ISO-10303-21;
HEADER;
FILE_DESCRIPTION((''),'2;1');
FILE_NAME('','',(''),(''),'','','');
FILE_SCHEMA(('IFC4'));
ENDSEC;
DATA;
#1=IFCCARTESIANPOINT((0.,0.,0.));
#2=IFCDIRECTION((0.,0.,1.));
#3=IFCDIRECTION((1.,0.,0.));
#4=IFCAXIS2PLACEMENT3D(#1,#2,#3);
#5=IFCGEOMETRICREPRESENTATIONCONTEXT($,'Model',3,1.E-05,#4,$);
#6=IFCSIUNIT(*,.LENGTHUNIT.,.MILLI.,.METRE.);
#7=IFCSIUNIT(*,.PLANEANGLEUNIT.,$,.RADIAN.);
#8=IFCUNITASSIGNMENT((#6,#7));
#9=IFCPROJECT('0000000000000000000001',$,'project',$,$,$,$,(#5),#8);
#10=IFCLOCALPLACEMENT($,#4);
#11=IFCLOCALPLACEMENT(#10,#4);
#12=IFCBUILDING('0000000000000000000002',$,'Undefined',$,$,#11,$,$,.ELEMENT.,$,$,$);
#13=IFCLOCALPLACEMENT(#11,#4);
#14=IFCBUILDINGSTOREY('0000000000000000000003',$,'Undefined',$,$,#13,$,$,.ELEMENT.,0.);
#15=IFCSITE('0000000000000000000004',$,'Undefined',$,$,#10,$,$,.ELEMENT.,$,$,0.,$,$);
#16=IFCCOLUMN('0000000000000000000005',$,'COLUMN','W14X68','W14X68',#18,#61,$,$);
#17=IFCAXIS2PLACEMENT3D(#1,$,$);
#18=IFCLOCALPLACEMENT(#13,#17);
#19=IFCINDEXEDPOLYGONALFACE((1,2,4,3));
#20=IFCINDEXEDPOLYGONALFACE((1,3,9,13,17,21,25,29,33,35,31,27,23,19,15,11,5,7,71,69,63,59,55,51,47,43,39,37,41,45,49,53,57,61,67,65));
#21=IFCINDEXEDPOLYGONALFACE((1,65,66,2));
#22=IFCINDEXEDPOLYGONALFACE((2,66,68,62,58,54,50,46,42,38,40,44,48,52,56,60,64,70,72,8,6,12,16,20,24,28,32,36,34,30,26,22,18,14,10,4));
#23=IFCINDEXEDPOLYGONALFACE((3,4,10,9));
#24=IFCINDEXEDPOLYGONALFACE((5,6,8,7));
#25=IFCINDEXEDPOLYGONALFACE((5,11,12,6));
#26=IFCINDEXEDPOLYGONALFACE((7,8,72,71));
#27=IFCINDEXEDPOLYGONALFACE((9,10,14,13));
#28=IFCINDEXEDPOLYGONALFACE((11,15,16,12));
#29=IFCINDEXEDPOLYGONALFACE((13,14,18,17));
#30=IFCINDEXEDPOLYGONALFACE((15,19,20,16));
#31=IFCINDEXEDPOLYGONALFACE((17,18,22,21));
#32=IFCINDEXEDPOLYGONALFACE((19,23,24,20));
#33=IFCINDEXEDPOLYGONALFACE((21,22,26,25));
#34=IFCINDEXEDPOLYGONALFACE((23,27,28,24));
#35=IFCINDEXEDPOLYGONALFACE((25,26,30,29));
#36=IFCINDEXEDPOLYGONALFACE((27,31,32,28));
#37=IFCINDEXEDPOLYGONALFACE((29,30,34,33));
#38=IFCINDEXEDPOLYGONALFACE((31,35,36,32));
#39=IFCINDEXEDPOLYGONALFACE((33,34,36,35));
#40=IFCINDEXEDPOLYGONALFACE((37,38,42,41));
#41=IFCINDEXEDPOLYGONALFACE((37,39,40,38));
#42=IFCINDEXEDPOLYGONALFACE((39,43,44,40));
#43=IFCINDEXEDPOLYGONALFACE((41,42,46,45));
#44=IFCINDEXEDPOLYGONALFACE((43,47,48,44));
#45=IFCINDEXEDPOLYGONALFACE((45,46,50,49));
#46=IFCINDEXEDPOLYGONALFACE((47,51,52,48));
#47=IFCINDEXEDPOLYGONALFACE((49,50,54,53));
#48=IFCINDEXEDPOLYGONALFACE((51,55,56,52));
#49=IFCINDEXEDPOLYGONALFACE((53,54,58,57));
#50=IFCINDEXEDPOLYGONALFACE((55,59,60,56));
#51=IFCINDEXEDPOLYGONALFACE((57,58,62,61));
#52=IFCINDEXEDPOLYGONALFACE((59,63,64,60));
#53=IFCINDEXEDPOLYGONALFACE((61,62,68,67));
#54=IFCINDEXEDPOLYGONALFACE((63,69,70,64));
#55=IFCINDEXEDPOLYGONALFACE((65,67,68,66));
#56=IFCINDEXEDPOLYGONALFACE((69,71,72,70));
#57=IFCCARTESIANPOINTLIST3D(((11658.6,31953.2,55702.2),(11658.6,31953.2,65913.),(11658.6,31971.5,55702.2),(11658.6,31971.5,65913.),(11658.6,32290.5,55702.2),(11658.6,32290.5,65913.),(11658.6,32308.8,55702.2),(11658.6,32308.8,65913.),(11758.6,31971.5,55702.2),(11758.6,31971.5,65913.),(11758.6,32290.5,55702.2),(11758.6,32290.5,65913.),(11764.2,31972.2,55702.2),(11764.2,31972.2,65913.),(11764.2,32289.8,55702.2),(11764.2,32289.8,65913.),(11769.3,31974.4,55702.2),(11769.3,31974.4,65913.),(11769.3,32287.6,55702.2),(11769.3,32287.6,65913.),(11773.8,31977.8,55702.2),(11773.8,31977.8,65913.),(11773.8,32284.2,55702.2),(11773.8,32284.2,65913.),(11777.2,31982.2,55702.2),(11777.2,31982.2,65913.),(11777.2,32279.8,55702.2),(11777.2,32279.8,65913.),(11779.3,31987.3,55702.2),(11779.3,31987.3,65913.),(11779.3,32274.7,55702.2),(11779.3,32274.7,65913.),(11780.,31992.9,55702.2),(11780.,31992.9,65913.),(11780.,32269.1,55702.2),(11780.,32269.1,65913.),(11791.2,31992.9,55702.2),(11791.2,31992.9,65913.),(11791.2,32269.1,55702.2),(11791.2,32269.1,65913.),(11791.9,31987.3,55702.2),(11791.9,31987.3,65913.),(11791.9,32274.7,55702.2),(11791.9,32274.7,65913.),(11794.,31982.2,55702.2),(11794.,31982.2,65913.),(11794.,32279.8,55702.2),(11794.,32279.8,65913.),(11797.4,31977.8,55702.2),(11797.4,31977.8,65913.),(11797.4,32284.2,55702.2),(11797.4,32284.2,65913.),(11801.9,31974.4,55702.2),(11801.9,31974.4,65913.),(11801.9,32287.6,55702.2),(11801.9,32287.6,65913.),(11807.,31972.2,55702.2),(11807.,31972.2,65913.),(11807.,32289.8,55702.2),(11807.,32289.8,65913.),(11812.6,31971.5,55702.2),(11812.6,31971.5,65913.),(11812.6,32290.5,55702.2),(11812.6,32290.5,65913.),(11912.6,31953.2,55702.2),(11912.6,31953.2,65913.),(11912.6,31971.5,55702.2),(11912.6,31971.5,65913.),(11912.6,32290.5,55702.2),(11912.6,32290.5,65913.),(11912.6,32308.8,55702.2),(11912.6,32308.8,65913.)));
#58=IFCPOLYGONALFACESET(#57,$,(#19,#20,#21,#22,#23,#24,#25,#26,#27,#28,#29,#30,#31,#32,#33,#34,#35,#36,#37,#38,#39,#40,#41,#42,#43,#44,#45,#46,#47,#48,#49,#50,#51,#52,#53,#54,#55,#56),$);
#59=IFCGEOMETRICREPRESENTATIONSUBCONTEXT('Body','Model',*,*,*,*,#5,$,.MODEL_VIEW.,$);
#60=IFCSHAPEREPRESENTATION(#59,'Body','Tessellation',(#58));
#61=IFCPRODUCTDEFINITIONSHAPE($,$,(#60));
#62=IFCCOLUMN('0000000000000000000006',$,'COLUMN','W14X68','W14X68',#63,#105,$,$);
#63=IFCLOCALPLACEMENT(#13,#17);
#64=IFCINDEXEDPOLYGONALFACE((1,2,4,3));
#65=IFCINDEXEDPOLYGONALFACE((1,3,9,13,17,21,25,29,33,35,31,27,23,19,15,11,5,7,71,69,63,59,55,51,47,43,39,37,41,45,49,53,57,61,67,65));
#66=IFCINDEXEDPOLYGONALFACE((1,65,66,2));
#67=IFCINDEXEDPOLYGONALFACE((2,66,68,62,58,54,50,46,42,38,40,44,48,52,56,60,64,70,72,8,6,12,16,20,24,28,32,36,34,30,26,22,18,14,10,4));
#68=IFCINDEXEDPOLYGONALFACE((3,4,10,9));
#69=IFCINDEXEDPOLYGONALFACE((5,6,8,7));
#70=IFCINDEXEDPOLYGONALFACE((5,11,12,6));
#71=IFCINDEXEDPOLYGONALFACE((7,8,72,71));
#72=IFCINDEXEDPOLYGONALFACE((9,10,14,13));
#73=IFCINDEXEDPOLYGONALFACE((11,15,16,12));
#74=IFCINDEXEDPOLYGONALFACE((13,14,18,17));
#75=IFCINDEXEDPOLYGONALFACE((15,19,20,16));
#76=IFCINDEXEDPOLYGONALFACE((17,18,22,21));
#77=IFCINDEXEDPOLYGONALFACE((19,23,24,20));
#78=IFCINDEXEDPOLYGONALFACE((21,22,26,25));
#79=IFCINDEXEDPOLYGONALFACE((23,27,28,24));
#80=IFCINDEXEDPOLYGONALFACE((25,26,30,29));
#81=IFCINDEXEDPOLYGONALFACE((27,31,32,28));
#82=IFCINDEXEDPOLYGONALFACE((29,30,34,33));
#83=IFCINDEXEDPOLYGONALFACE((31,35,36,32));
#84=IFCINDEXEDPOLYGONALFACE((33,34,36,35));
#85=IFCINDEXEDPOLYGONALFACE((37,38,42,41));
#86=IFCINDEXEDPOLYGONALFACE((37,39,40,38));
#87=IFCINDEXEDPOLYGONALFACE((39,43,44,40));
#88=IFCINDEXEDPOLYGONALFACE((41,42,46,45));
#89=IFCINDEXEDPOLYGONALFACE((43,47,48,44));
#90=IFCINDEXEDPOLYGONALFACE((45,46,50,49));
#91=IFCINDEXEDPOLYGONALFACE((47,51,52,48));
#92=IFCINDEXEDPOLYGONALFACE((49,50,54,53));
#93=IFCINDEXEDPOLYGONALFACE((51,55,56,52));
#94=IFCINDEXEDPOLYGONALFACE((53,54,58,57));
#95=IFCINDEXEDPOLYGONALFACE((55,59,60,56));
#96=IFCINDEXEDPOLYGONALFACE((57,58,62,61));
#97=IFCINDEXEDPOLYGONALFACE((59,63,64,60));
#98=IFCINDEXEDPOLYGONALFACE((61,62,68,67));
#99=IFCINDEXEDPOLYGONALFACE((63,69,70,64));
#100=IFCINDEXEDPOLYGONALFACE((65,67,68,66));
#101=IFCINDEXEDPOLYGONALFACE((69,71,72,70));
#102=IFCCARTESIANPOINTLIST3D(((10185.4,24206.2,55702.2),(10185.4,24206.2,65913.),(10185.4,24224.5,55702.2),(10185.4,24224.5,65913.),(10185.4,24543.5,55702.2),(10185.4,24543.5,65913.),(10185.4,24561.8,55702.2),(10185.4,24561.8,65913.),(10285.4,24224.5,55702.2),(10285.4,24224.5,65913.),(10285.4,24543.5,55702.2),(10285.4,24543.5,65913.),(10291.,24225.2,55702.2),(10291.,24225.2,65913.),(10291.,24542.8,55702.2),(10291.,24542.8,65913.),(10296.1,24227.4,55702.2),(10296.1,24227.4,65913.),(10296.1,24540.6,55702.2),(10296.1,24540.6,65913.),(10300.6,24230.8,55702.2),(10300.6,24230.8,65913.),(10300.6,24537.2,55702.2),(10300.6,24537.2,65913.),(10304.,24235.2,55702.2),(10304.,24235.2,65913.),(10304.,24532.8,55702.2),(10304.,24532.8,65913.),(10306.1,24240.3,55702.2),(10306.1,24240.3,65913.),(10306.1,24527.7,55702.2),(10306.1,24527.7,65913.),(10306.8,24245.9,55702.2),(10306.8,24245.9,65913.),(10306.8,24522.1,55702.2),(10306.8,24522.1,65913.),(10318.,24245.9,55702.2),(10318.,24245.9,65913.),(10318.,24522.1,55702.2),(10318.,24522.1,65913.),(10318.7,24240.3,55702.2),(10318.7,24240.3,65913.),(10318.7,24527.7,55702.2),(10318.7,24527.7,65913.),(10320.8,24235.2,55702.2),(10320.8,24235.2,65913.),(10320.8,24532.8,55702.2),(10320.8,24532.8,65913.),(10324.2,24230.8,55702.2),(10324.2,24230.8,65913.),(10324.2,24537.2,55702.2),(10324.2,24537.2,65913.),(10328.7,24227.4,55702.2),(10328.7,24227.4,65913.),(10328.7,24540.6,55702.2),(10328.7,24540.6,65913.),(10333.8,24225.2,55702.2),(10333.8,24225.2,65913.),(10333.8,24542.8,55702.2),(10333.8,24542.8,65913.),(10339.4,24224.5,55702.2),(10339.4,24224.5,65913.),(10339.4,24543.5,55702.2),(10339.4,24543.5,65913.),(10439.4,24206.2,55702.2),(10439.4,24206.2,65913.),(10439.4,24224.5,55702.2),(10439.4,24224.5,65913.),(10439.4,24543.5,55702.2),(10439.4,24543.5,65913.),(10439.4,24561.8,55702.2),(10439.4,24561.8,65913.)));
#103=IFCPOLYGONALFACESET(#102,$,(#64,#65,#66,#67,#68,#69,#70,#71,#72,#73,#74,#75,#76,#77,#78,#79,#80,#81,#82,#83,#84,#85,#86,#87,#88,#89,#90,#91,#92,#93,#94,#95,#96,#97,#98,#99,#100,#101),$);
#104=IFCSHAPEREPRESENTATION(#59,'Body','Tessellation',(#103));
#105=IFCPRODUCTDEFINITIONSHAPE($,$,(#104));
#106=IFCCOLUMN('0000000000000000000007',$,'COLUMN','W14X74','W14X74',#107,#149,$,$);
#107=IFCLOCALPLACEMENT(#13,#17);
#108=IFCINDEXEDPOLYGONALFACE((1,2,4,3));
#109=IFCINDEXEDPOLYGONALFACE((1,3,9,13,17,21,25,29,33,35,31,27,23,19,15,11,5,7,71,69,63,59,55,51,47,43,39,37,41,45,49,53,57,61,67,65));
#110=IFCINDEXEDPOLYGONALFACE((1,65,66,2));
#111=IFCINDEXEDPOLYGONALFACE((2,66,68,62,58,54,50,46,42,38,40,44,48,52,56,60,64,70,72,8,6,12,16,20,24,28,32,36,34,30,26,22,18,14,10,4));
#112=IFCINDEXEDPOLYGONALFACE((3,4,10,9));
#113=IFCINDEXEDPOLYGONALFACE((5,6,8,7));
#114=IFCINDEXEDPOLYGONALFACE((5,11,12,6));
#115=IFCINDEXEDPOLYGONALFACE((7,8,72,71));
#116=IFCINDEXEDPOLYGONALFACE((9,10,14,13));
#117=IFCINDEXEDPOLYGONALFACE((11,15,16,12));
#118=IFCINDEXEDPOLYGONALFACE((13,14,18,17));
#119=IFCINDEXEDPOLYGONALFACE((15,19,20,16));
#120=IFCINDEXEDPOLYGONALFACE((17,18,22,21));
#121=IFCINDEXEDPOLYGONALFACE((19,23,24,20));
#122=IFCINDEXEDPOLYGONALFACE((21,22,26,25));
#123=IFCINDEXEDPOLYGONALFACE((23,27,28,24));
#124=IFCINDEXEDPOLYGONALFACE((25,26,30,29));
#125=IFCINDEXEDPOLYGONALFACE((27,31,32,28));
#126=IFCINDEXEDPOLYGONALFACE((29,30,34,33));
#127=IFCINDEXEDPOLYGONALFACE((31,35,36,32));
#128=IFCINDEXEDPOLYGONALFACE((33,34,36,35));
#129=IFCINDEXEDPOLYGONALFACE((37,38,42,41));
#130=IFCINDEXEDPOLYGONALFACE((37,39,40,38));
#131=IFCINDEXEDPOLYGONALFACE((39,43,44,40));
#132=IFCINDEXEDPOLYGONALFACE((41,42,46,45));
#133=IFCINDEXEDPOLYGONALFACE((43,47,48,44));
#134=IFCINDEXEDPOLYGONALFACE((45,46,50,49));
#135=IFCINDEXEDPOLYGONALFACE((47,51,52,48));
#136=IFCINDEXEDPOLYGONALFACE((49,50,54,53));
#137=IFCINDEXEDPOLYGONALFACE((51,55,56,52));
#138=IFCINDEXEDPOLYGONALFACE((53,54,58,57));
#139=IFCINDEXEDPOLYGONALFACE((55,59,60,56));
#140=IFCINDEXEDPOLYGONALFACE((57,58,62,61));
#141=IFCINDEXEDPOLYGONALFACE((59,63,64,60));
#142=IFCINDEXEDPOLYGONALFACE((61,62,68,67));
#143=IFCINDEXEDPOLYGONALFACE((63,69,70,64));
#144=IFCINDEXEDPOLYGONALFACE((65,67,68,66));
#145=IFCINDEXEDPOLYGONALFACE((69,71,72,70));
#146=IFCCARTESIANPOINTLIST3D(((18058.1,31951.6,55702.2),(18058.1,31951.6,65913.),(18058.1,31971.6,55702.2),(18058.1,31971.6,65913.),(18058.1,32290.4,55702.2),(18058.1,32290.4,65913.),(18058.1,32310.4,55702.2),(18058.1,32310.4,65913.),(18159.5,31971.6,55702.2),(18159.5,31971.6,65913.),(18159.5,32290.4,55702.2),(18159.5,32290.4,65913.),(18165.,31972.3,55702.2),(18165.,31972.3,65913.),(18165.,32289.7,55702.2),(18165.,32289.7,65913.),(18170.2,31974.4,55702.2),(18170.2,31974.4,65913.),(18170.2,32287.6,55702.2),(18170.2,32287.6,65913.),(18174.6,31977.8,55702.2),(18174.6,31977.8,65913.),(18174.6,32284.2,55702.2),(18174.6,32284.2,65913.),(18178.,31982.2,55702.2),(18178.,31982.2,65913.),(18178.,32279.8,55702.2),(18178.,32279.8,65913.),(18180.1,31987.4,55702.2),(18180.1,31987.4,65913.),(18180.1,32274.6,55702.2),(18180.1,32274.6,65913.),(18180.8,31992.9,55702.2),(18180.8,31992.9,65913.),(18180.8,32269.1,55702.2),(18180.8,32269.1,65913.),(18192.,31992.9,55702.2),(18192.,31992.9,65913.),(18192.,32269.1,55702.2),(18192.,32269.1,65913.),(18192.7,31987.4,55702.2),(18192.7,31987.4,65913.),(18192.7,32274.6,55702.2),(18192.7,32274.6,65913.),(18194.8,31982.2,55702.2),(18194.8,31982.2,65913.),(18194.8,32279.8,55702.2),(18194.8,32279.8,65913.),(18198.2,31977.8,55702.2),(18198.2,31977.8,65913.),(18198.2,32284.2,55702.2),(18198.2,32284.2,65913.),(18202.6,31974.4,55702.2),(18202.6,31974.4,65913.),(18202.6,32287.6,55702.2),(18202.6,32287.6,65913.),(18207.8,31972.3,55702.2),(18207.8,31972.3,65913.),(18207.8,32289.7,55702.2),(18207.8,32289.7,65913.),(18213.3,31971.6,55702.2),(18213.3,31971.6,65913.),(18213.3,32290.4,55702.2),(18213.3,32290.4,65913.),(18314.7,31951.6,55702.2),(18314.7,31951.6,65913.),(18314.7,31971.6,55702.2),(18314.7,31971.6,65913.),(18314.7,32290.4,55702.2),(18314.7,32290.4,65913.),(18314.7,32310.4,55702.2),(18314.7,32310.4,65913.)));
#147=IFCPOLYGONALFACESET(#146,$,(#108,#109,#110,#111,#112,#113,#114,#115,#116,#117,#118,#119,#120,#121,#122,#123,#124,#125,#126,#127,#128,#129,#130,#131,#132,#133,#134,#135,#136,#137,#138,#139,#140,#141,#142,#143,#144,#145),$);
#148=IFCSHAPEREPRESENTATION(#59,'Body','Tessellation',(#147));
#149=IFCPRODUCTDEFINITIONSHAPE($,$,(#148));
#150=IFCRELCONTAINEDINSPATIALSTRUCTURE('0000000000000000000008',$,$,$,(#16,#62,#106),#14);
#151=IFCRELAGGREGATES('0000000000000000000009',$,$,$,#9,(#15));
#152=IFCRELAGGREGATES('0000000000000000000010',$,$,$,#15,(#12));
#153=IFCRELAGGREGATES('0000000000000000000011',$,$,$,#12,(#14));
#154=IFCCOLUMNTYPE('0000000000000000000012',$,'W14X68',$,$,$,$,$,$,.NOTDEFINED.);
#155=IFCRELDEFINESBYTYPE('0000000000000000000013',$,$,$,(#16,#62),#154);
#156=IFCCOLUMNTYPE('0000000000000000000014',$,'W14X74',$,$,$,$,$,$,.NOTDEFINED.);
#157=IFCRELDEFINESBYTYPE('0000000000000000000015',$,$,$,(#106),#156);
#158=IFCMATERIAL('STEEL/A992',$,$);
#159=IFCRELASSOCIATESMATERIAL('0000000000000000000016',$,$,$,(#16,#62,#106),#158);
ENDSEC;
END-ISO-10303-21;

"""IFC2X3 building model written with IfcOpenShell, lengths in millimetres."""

from ifc_helpers import new_model, si_unit, frame, origin_with_axes, origin_2d_with_axis, place, context, subcontext, project, spatial, i_section, extrude, material, type_object, element, save


model = new_model("IFC2X3")

# Units and contexts
model_context = context("Model", 3, precision=1e-05, world=origin_with_axes())
body_context = subcontext(model_context, "Body", "Model", "MODEL_VIEW")
ifc_project = project(units=[si_unit("LENGTHUNIT", "METRE", prefix="MILLI"), si_unit("PLANEANGLEUNIT", "RADIAN")], contexts=[model_context])

# Site, building, storey
site_placement = place(None, origin_with_axes())
site = spatial("IfcSite", under=ifc_project, at=site_placement, Name="Undefined", CompositionType="ELEMENT", RefElevation=0.0)
building_placement = place(site_placement, origin_with_axes())
building = spatial("IfcBuilding", under=site, at=building_placement, Name="Undefined", CompositionType="ELEMENT")
storey_placement = place(building_placement, origin_with_axes())
storey = spatial("IfcBuildingStorey", under=building, at=storey_placement, Name="Undefined", CompositionType="ELEMENT", Elevation=0.0)

# Columns
ifc_material_1 = material(Name="STEEL/A992")
column_type_1 = type_object("IfcColumnType", Name="W14X68", PredefinedType="NOTDEFINED")
for number, where, z_axis, x_axis, name in (
    (1, (11785.6, 32131.0, 55702.2), (0.0, 0.0, 1.0), (1.0, 0.0, 0.0), "COLUMN"),
    (2, (10312.4, 24384.0, 55702.2), (0.0, 0.0, 1.0), (1.0, 0.0, 0.0), "COLUMN"),
):
    element("IfcColumn", number, at=place(storey_placement, frame(where, z_axis=z_axis, x_axis=x_axis)), inside=storey, type_object=column_type_1, material=ifc_material_1, Name=name, Description="W14X68", ObjectType="W14X68", context=body_context, shape_type="SweptSolid", body=[
        extrude(i_section(OverallWidth=254.0, OverallDepth=355.6, WebThickness=11.1, FlangeThickness=18.3, FilletRadius=21.4, at=origin_2d_with_axis()), frame((0.0, 0.0, 10210.8), z_axis=(0.0, 0.0, -1.0), x_axis=(-1.0, 0.0, 0.0)), (0.0, 0.0, 1.0), 10210.8),
    ])
column_type_2 = type_object("IfcColumnType", Name="W14X74", PredefinedType="NOTDEFINED")
column_placement = place(storey_placement, frame((18186.4, 32131.0, 55702.2), z_axis=(0.0, 0.0, 1.0), x_axis=(1.0, 0.0, 0.0)))
element("IfcColumn", 3, at=column_placement, inside=storey, type_object=column_type_2, material=ifc_material_1, Name="COLUMN", Description="W14X74", ObjectType="W14X74", context=body_context, shape_type="SweptSolid", body=[
    extrude(i_section(OverallWidth=256.5, OverallDepth=358.8, WebThickness=11.1, FlangeThickness=19.9, FilletRadius=21.3, at=origin_2d_with_axis()), frame((0.0, 0.0, 10210.8), z_axis=(0.0, 0.0, -1.0), x_axis=(-1.0, 0.0, 0.0)), (0.0, 0.0, 1.0), 10210.8),
])

save(model, "model.ifc")
